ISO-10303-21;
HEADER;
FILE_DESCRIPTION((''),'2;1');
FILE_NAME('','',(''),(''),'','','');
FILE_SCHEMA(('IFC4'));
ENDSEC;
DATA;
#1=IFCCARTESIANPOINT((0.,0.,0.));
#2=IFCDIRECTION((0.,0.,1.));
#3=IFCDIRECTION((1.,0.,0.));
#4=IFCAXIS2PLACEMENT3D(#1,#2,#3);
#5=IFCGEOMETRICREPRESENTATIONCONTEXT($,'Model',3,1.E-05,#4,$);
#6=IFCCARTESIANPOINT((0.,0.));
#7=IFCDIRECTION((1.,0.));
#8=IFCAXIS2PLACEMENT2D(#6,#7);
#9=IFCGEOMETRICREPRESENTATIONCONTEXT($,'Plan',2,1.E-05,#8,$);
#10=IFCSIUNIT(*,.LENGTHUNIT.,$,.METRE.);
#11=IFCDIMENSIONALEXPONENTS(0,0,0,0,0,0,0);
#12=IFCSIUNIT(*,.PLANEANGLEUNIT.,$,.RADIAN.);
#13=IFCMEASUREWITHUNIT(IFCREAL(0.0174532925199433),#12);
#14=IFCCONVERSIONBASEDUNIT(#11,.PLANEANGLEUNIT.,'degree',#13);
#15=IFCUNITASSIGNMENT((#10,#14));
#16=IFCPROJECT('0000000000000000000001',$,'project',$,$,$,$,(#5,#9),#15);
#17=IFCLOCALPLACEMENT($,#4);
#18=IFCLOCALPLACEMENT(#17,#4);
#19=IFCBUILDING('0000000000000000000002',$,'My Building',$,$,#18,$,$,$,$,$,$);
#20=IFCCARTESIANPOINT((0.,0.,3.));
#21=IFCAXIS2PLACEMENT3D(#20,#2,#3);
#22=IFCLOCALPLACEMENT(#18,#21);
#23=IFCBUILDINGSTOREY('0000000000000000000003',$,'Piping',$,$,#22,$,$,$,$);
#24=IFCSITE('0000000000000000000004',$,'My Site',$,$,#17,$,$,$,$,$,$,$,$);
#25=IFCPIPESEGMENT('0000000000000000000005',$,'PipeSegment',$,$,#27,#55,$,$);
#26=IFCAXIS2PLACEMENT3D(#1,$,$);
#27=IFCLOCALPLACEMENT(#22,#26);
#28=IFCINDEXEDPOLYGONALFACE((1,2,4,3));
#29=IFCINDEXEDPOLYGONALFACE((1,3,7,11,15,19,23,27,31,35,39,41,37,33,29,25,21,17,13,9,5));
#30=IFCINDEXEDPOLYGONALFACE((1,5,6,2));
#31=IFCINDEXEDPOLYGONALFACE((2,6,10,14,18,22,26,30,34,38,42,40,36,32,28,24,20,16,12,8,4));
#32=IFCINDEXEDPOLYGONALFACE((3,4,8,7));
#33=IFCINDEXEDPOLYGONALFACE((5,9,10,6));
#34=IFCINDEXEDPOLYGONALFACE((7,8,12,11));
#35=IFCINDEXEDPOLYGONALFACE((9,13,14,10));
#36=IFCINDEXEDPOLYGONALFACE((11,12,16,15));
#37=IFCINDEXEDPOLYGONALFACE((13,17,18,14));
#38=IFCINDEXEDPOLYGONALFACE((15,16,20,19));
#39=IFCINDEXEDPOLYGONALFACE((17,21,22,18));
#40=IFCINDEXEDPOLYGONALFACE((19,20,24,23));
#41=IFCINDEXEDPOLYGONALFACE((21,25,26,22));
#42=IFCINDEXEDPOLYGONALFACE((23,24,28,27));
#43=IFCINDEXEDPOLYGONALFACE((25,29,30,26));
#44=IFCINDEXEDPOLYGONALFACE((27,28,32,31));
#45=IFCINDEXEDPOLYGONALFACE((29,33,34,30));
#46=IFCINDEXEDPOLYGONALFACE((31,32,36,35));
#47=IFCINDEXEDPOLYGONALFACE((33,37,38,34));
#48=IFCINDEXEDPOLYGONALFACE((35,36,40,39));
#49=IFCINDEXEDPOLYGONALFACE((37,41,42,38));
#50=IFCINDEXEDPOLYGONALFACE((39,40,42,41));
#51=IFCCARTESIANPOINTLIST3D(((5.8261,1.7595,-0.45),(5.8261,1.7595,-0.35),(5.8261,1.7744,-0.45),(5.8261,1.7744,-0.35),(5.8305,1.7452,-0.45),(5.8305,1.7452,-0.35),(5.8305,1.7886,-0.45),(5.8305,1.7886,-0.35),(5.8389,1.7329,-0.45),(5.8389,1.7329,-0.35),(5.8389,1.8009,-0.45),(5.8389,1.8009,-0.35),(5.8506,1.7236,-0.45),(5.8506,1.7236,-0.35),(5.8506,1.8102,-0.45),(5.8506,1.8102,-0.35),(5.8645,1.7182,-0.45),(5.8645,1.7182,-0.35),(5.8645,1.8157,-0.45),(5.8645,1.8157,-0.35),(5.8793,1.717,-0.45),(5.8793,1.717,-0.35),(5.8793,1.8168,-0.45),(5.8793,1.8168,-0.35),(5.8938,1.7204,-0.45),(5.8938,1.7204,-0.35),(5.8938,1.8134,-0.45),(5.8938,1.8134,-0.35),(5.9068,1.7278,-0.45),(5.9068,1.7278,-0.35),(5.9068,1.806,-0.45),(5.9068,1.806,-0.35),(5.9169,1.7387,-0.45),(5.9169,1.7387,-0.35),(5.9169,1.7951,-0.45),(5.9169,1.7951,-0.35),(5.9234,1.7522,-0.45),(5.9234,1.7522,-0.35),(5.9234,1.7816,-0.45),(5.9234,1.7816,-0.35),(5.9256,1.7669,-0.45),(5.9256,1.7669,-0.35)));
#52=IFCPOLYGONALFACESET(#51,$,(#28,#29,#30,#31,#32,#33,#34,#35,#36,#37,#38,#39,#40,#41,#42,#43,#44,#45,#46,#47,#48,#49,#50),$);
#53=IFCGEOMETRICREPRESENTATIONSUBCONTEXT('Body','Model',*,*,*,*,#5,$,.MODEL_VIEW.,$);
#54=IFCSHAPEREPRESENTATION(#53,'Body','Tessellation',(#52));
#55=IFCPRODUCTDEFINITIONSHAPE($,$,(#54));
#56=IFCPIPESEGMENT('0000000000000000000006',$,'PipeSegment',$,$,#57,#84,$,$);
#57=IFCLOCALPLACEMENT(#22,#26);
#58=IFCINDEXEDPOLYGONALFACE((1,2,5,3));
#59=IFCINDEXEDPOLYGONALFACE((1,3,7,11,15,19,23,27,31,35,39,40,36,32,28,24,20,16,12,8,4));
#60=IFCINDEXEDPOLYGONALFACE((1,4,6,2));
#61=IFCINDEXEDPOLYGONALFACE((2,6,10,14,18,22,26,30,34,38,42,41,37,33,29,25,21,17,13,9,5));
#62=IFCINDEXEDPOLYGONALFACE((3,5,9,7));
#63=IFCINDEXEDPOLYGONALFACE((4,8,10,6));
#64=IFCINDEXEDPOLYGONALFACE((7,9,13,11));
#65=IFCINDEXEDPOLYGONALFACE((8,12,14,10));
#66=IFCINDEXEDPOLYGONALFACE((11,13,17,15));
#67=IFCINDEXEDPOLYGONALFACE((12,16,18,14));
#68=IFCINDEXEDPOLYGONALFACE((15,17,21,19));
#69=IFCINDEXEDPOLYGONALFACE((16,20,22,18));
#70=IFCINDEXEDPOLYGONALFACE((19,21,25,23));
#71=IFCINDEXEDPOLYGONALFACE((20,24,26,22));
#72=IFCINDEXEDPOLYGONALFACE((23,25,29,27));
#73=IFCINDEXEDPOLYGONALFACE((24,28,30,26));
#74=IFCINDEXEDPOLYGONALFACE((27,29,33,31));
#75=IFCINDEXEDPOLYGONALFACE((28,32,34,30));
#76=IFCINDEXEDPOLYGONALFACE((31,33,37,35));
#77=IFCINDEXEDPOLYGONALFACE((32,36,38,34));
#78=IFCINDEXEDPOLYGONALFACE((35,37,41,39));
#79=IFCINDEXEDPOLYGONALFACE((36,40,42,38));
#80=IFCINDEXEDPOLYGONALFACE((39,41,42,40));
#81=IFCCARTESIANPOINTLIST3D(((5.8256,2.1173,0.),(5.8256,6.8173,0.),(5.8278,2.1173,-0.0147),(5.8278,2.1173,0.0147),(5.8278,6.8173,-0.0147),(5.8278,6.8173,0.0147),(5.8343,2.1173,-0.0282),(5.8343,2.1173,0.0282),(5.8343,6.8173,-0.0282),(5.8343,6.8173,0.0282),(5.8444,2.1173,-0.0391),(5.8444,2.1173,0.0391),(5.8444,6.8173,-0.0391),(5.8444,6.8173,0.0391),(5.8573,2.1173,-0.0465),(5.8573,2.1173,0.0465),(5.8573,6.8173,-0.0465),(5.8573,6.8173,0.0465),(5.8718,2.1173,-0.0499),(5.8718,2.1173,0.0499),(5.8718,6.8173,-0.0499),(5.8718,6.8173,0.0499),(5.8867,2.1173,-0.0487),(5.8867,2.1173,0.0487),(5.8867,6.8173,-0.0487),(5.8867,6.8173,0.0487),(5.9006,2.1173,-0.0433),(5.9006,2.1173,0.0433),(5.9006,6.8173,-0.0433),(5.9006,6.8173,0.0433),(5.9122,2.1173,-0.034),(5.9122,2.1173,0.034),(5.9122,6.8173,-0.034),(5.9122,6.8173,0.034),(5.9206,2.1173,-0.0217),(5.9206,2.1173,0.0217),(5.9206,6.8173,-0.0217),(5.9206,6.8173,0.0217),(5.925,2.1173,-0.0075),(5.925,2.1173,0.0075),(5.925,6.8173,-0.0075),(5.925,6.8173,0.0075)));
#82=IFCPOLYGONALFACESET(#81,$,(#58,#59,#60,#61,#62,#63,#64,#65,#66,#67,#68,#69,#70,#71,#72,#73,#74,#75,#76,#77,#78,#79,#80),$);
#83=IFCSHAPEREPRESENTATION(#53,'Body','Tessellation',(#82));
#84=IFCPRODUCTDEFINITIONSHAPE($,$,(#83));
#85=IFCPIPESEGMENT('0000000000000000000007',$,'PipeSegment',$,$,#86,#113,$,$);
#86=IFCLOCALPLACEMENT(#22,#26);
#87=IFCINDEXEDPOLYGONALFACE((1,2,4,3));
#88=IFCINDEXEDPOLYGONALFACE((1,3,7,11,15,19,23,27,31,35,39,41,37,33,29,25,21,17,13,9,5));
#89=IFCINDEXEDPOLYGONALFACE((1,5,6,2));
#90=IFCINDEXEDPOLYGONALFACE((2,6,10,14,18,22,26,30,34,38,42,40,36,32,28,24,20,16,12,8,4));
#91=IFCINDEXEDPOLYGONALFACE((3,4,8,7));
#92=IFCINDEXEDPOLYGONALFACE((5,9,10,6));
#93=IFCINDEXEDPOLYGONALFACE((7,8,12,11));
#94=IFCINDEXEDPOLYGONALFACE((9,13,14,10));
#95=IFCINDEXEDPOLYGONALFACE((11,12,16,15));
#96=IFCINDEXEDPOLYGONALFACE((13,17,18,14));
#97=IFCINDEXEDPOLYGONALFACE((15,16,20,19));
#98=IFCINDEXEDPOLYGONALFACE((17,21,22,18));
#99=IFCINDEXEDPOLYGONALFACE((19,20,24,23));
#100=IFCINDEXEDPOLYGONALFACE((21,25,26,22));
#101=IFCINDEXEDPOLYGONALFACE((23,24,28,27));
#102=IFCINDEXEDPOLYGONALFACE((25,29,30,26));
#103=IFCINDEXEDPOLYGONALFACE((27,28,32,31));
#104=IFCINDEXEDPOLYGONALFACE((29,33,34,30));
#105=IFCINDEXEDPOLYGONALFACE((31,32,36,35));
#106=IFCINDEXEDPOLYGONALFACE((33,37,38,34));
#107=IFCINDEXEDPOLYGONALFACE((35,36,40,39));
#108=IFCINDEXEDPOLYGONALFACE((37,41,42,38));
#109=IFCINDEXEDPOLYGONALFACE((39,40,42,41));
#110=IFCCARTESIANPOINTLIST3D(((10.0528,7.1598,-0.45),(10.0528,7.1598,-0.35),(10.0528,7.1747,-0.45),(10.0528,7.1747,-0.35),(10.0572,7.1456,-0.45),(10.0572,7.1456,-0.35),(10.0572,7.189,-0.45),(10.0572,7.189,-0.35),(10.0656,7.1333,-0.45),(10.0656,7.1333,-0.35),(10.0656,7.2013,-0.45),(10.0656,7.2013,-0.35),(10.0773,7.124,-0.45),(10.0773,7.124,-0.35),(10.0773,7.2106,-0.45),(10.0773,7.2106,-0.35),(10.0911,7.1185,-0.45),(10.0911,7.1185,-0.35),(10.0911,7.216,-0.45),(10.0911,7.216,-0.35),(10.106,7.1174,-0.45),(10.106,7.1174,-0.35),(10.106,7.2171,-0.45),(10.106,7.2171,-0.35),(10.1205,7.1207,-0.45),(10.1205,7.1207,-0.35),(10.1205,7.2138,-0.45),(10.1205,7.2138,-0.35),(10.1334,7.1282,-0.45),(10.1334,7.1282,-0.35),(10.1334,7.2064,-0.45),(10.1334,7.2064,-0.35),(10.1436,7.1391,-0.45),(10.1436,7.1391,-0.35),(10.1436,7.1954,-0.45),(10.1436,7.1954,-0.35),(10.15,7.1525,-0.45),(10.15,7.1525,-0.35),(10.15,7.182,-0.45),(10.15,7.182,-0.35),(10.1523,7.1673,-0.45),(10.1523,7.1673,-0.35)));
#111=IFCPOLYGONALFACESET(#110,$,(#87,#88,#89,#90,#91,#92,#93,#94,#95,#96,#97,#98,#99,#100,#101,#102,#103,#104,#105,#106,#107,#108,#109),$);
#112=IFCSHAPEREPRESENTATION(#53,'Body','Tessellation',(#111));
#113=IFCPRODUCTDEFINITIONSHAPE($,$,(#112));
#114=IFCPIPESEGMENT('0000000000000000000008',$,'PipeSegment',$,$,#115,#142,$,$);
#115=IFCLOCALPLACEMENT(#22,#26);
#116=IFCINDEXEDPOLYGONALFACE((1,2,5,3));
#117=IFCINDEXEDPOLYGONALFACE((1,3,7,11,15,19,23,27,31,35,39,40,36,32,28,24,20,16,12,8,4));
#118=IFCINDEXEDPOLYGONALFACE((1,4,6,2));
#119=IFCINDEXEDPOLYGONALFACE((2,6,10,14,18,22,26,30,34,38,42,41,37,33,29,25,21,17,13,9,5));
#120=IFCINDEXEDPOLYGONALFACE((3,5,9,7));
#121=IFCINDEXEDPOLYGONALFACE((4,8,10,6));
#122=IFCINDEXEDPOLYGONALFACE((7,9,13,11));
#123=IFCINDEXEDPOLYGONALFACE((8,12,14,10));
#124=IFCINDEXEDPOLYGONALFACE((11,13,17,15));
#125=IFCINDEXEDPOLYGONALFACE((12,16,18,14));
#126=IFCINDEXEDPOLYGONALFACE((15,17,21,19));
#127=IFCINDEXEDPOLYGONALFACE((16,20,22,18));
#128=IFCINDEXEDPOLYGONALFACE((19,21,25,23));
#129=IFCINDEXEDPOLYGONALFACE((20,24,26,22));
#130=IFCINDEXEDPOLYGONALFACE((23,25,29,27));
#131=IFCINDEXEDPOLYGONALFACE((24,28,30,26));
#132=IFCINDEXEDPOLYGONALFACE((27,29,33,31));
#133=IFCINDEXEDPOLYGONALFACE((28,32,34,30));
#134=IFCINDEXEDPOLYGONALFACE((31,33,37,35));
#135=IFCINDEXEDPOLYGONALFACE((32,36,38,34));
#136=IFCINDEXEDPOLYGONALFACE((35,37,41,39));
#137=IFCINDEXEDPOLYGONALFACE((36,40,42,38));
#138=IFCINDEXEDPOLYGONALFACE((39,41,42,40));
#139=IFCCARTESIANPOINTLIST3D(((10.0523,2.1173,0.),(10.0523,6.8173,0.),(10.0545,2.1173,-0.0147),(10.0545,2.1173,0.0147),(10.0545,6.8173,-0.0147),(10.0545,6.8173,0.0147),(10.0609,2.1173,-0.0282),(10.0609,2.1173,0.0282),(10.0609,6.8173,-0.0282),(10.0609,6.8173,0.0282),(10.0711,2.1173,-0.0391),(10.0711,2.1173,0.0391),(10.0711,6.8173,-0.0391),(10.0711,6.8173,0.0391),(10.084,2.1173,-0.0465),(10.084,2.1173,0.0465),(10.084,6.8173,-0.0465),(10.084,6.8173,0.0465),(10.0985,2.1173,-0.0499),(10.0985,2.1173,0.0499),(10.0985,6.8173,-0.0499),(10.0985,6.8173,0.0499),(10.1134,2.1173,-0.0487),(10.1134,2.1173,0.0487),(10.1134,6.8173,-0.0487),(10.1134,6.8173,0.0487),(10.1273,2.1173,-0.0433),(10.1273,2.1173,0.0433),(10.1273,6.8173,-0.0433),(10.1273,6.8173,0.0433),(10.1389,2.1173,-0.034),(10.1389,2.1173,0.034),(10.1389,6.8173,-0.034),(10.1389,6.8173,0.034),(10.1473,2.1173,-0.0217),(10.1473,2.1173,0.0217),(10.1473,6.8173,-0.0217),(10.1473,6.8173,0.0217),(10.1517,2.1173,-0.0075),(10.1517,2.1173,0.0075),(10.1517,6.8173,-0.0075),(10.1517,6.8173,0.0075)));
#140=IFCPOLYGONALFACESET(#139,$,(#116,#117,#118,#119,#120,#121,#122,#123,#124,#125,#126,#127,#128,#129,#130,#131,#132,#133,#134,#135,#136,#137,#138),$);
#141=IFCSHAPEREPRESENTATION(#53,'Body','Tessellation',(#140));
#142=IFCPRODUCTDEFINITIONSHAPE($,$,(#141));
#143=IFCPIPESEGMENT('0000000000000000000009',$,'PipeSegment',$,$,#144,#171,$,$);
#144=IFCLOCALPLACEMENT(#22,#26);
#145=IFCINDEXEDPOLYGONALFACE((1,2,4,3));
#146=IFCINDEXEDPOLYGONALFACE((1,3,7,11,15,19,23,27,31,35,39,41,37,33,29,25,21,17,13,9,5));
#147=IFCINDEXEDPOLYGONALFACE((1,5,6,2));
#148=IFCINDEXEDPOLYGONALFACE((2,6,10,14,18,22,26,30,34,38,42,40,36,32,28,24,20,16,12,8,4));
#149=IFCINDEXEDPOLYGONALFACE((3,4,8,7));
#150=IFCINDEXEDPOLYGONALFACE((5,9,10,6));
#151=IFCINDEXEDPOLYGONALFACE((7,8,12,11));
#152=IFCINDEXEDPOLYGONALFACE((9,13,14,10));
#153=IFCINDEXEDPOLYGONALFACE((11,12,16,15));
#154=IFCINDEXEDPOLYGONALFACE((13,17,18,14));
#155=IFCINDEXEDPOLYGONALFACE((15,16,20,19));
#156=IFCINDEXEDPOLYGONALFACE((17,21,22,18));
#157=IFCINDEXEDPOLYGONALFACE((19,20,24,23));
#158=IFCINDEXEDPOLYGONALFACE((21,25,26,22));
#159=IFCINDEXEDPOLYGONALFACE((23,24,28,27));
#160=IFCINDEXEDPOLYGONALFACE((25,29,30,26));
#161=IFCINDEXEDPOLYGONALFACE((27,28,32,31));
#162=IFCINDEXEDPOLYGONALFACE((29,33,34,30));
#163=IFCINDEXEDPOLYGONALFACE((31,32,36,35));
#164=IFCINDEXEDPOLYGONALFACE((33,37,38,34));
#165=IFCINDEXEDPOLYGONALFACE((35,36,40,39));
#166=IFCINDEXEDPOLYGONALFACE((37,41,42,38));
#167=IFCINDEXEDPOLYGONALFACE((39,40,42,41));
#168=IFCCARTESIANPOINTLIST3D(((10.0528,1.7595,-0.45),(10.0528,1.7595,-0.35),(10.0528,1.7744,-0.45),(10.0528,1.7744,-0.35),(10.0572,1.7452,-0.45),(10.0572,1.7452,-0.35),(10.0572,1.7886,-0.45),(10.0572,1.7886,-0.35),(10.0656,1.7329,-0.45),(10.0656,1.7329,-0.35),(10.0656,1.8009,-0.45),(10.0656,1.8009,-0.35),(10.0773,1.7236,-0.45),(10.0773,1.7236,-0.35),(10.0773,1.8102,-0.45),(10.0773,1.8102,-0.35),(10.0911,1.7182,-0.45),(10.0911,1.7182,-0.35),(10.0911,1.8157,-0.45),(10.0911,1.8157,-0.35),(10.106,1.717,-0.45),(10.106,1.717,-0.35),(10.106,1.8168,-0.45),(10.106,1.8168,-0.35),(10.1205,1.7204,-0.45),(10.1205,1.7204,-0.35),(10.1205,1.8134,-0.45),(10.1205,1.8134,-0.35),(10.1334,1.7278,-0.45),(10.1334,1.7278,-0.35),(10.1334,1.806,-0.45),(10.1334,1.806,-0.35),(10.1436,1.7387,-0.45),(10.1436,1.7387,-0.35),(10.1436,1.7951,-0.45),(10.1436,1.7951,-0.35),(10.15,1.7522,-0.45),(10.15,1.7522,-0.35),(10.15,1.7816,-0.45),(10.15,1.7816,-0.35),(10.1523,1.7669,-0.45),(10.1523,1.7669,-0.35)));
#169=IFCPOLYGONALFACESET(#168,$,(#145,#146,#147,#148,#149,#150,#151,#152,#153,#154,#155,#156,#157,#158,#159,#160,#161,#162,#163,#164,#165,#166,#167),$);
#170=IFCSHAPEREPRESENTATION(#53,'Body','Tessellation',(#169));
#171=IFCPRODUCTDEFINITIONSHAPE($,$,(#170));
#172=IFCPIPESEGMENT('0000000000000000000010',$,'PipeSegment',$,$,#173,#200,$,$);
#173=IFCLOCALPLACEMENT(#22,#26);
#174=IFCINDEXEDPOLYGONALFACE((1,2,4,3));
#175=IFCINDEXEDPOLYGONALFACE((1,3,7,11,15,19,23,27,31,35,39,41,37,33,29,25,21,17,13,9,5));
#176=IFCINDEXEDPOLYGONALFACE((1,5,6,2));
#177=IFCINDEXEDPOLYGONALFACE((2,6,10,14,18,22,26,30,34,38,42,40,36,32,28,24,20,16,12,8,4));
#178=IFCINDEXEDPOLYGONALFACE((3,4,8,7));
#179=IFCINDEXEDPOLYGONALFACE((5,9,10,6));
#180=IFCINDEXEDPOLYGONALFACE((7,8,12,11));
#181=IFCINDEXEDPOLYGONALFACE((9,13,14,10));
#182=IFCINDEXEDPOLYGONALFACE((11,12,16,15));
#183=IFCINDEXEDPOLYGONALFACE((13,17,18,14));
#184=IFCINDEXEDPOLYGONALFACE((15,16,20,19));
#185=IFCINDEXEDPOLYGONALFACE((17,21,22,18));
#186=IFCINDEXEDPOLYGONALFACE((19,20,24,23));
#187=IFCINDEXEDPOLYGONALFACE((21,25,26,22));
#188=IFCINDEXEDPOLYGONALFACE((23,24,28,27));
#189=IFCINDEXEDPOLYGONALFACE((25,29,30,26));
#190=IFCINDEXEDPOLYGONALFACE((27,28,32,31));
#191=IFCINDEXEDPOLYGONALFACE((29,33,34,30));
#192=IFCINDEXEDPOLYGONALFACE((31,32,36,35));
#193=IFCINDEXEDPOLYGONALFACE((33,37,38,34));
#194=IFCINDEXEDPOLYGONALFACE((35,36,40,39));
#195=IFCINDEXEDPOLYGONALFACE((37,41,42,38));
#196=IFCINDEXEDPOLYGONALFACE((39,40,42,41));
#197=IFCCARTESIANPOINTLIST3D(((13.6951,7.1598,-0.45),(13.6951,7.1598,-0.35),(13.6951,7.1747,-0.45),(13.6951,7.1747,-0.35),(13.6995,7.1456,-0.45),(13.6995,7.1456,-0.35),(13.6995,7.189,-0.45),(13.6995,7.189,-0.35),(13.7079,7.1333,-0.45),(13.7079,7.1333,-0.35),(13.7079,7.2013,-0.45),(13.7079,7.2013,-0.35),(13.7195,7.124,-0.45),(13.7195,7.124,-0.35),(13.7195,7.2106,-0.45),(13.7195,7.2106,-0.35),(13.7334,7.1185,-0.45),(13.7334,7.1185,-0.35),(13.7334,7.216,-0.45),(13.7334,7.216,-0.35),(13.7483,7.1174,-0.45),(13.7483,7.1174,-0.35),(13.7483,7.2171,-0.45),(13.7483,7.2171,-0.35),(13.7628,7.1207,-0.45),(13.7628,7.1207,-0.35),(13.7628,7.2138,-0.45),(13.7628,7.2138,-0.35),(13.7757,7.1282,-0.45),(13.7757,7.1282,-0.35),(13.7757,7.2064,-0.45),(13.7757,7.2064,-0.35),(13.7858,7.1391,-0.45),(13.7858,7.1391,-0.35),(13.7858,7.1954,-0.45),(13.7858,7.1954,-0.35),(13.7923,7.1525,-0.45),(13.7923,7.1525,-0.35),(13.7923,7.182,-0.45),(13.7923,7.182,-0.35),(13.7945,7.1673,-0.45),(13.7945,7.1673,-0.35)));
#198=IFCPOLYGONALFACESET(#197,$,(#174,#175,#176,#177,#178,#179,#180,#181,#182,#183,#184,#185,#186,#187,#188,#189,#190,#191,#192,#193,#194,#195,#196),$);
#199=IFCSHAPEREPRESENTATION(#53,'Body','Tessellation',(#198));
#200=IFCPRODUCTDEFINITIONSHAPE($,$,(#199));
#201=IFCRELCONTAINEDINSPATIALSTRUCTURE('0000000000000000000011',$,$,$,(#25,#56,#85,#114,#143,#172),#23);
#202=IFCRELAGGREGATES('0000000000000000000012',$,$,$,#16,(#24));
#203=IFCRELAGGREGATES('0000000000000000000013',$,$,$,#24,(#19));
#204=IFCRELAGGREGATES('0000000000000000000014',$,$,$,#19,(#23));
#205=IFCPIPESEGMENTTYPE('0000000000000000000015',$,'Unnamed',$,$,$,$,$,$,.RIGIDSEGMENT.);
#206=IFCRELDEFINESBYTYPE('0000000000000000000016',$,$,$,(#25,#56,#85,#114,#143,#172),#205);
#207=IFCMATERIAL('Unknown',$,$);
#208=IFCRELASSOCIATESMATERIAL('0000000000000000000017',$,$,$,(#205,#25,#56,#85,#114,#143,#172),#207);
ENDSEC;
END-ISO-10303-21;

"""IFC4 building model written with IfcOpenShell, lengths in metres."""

from ifc_helpers import new_model, entity, si_unit, converted_unit, frame, origin_with_axes, origin_2d_with_axis, place, context, subcontext, project, spatial, circle, extrude, material, material_profile, profile_set, profile_usage, type_object, element, save


model = new_model("IFC4")

# Units and contexts
model_context = context("Model", 3, precision=1e-05, world=origin_with_axes())
plan_context = context("Plan", 2, precision=1e-05, world=origin_2d_with_axis())
body_context = subcontext(model_context, "Body", "Model", "MODEL_VIEW")
ifc_project = project(units=[si_unit("LENGTHUNIT", "METRE"), converted_unit("PLANEANGLEUNIT", "degree", entity("IfcReal", 0.0174532925199433), si_unit("PLANEANGLEUNIT", "RADIAN"), dimensions=[0, 0, 0, 0, 0, 0, 0])], contexts=[model_context, plan_context])

# Site, building, storey
site_placement = place(None, origin_with_axes())
site = spatial("IfcSite", under=ifc_project, at=site_placement, Name="My Site")
building_placement = place(site_placement, origin_with_axes())
building = spatial("IfcBuilding", under=site, at=building_placement, Name="My Building")
storey_placement = place(building_placement, frame((0.0, 0.0, 3.0), z_axis=(0.0, 0.0, 1.0), x_axis=(1.0, 0.0, 0.0)))
storey = spatial("IfcBuildingStorey", under=building, at=storey_placement, Name="Piping")

# Pipe segments
ifc_material = material(Name="Unknown")
ifc_material_profile = material_profile(ifc_material, circle(Radius=0.05))
ifc_profile_set = profile_set([ifc_material_profile])
pipe_segment_type = type_object("IfcPipeSegmentType", Name="Unnamed", PredefinedType="RIGIDSEGMENT", material=ifc_profile_set)
ifc_profile_usage_1 = profile_usage(ifc_profile_set, cardinal=5)
pipe_segment_1_placement = place(storey_placement, frame((5.8756, 1.7669, -0.35), z_axis=(0.0, 0.0, -1.0), x_axis=(1.0, 0.0, 0.0)))
element("IfcPipeSegment", 1, at=pipe_segment_1_placement, inside=storey, type_object=pipe_segment_type, material=ifc_profile_usage_1, Name="PipeSegment", context=body_context, shape_type="SweptSolid", body=[
    extrude(circle(Radius=0.05), origin_with_axes(), (0.0, 0.0, 1.0), 0.1),
])
ifc_profile_usage_2 = profile_usage(ifc_profile_set, cardinal=5)
pipe_segment_2_placement = place(storey_placement, frame((5.8756, 2.1173, 0.0), z_axis=(0.0, 1.0, 0.0), x_axis=(-1.0, 0.0, 0.0)))
element("IfcPipeSegment", 2, at=pipe_segment_2_placement, inside=storey, type_object=pipe_segment_type, material=ifc_profile_usage_2, Name="PipeSegment", context=body_context, shape_type="SweptSolid", body=[
    extrude(circle(Radius=0.05), origin_with_axes(), (0.0, 0.0, 1.0), 4.7),
])
ifc_profile_usage_3 = profile_usage(ifc_profile_set, cardinal=5)
pipe_segment_3_placement = place(storey_placement, frame((10.1023, 7.1673, -0.35), z_axis=(0.0, 0.0, -1.0), x_axis=(1.0, 0.0, 0.0)))
element("IfcPipeSegment", 3, at=pipe_segment_3_placement, inside=storey, type_object=pipe_segment_type, material=ifc_profile_usage_3, Name="PipeSegment", context=body_context, shape_type="SweptSolid", body=[
    extrude(circle(Radius=0.05), origin_with_axes(), (0.0, 0.0, 1.0), 0.1),
])
ifc_profile_usage_4 = profile_usage(ifc_profile_set, cardinal=5)
pipe_segment_4_placement = place(storey_placement, frame((10.1023, 2.1173, 0.0), z_axis=(0.0, 1.0, 0.0), x_axis=(-1.0, 0.0, 0.0)))
element("IfcPipeSegment", 4, at=pipe_segment_4_placement, inside=storey, type_object=pipe_segment_type, material=ifc_profile_usage_4, Name="PipeSegment", context=body_context, shape_type="SweptSolid", body=[
    extrude(circle(Radius=0.05), origin_with_axes(), (0.0, 0.0, 1.0), 4.7),
])
ifc_profile_usage_5 = profile_usage(ifc_profile_set, cardinal=5)
pipe_segment_5_placement = place(storey_placement, frame((10.1023, 1.7669, -0.35), z_axis=(0.0, 0.0, -1.0), x_axis=(1.0, 0.0, 0.0)))
element("IfcPipeSegment", 5, at=pipe_segment_5_placement, inside=storey, type_object=pipe_segment_type, material=ifc_profile_usage_5, Name="PipeSegment", context=body_context, shape_type="SweptSolid", body=[
    extrude(circle(Radius=0.05), origin_with_axes(), (0.0, 0.0, 1.0), 0.1),
])
ifc_profile_usage_6 = profile_usage(ifc_profile_set, cardinal=5)
pipe_segment_6_placement = place(storey_placement, frame((13.7445, 7.1673, -0.35), z_axis=(0.0, 0.0, -1.0), x_axis=(1.0, 0.0, 0.0)))
element("IfcPipeSegment", 6, at=pipe_segment_6_placement, inside=storey, type_object=pipe_segment_type, material=ifc_profile_usage_6, Name="PipeSegment", context=body_context, shape_type="SweptSolid", body=[
    extrude(circle(Radius=0.05), origin_with_axes(), (0.0, 0.0, 1.0), 0.1),
])

save(model, "model.ifc")
